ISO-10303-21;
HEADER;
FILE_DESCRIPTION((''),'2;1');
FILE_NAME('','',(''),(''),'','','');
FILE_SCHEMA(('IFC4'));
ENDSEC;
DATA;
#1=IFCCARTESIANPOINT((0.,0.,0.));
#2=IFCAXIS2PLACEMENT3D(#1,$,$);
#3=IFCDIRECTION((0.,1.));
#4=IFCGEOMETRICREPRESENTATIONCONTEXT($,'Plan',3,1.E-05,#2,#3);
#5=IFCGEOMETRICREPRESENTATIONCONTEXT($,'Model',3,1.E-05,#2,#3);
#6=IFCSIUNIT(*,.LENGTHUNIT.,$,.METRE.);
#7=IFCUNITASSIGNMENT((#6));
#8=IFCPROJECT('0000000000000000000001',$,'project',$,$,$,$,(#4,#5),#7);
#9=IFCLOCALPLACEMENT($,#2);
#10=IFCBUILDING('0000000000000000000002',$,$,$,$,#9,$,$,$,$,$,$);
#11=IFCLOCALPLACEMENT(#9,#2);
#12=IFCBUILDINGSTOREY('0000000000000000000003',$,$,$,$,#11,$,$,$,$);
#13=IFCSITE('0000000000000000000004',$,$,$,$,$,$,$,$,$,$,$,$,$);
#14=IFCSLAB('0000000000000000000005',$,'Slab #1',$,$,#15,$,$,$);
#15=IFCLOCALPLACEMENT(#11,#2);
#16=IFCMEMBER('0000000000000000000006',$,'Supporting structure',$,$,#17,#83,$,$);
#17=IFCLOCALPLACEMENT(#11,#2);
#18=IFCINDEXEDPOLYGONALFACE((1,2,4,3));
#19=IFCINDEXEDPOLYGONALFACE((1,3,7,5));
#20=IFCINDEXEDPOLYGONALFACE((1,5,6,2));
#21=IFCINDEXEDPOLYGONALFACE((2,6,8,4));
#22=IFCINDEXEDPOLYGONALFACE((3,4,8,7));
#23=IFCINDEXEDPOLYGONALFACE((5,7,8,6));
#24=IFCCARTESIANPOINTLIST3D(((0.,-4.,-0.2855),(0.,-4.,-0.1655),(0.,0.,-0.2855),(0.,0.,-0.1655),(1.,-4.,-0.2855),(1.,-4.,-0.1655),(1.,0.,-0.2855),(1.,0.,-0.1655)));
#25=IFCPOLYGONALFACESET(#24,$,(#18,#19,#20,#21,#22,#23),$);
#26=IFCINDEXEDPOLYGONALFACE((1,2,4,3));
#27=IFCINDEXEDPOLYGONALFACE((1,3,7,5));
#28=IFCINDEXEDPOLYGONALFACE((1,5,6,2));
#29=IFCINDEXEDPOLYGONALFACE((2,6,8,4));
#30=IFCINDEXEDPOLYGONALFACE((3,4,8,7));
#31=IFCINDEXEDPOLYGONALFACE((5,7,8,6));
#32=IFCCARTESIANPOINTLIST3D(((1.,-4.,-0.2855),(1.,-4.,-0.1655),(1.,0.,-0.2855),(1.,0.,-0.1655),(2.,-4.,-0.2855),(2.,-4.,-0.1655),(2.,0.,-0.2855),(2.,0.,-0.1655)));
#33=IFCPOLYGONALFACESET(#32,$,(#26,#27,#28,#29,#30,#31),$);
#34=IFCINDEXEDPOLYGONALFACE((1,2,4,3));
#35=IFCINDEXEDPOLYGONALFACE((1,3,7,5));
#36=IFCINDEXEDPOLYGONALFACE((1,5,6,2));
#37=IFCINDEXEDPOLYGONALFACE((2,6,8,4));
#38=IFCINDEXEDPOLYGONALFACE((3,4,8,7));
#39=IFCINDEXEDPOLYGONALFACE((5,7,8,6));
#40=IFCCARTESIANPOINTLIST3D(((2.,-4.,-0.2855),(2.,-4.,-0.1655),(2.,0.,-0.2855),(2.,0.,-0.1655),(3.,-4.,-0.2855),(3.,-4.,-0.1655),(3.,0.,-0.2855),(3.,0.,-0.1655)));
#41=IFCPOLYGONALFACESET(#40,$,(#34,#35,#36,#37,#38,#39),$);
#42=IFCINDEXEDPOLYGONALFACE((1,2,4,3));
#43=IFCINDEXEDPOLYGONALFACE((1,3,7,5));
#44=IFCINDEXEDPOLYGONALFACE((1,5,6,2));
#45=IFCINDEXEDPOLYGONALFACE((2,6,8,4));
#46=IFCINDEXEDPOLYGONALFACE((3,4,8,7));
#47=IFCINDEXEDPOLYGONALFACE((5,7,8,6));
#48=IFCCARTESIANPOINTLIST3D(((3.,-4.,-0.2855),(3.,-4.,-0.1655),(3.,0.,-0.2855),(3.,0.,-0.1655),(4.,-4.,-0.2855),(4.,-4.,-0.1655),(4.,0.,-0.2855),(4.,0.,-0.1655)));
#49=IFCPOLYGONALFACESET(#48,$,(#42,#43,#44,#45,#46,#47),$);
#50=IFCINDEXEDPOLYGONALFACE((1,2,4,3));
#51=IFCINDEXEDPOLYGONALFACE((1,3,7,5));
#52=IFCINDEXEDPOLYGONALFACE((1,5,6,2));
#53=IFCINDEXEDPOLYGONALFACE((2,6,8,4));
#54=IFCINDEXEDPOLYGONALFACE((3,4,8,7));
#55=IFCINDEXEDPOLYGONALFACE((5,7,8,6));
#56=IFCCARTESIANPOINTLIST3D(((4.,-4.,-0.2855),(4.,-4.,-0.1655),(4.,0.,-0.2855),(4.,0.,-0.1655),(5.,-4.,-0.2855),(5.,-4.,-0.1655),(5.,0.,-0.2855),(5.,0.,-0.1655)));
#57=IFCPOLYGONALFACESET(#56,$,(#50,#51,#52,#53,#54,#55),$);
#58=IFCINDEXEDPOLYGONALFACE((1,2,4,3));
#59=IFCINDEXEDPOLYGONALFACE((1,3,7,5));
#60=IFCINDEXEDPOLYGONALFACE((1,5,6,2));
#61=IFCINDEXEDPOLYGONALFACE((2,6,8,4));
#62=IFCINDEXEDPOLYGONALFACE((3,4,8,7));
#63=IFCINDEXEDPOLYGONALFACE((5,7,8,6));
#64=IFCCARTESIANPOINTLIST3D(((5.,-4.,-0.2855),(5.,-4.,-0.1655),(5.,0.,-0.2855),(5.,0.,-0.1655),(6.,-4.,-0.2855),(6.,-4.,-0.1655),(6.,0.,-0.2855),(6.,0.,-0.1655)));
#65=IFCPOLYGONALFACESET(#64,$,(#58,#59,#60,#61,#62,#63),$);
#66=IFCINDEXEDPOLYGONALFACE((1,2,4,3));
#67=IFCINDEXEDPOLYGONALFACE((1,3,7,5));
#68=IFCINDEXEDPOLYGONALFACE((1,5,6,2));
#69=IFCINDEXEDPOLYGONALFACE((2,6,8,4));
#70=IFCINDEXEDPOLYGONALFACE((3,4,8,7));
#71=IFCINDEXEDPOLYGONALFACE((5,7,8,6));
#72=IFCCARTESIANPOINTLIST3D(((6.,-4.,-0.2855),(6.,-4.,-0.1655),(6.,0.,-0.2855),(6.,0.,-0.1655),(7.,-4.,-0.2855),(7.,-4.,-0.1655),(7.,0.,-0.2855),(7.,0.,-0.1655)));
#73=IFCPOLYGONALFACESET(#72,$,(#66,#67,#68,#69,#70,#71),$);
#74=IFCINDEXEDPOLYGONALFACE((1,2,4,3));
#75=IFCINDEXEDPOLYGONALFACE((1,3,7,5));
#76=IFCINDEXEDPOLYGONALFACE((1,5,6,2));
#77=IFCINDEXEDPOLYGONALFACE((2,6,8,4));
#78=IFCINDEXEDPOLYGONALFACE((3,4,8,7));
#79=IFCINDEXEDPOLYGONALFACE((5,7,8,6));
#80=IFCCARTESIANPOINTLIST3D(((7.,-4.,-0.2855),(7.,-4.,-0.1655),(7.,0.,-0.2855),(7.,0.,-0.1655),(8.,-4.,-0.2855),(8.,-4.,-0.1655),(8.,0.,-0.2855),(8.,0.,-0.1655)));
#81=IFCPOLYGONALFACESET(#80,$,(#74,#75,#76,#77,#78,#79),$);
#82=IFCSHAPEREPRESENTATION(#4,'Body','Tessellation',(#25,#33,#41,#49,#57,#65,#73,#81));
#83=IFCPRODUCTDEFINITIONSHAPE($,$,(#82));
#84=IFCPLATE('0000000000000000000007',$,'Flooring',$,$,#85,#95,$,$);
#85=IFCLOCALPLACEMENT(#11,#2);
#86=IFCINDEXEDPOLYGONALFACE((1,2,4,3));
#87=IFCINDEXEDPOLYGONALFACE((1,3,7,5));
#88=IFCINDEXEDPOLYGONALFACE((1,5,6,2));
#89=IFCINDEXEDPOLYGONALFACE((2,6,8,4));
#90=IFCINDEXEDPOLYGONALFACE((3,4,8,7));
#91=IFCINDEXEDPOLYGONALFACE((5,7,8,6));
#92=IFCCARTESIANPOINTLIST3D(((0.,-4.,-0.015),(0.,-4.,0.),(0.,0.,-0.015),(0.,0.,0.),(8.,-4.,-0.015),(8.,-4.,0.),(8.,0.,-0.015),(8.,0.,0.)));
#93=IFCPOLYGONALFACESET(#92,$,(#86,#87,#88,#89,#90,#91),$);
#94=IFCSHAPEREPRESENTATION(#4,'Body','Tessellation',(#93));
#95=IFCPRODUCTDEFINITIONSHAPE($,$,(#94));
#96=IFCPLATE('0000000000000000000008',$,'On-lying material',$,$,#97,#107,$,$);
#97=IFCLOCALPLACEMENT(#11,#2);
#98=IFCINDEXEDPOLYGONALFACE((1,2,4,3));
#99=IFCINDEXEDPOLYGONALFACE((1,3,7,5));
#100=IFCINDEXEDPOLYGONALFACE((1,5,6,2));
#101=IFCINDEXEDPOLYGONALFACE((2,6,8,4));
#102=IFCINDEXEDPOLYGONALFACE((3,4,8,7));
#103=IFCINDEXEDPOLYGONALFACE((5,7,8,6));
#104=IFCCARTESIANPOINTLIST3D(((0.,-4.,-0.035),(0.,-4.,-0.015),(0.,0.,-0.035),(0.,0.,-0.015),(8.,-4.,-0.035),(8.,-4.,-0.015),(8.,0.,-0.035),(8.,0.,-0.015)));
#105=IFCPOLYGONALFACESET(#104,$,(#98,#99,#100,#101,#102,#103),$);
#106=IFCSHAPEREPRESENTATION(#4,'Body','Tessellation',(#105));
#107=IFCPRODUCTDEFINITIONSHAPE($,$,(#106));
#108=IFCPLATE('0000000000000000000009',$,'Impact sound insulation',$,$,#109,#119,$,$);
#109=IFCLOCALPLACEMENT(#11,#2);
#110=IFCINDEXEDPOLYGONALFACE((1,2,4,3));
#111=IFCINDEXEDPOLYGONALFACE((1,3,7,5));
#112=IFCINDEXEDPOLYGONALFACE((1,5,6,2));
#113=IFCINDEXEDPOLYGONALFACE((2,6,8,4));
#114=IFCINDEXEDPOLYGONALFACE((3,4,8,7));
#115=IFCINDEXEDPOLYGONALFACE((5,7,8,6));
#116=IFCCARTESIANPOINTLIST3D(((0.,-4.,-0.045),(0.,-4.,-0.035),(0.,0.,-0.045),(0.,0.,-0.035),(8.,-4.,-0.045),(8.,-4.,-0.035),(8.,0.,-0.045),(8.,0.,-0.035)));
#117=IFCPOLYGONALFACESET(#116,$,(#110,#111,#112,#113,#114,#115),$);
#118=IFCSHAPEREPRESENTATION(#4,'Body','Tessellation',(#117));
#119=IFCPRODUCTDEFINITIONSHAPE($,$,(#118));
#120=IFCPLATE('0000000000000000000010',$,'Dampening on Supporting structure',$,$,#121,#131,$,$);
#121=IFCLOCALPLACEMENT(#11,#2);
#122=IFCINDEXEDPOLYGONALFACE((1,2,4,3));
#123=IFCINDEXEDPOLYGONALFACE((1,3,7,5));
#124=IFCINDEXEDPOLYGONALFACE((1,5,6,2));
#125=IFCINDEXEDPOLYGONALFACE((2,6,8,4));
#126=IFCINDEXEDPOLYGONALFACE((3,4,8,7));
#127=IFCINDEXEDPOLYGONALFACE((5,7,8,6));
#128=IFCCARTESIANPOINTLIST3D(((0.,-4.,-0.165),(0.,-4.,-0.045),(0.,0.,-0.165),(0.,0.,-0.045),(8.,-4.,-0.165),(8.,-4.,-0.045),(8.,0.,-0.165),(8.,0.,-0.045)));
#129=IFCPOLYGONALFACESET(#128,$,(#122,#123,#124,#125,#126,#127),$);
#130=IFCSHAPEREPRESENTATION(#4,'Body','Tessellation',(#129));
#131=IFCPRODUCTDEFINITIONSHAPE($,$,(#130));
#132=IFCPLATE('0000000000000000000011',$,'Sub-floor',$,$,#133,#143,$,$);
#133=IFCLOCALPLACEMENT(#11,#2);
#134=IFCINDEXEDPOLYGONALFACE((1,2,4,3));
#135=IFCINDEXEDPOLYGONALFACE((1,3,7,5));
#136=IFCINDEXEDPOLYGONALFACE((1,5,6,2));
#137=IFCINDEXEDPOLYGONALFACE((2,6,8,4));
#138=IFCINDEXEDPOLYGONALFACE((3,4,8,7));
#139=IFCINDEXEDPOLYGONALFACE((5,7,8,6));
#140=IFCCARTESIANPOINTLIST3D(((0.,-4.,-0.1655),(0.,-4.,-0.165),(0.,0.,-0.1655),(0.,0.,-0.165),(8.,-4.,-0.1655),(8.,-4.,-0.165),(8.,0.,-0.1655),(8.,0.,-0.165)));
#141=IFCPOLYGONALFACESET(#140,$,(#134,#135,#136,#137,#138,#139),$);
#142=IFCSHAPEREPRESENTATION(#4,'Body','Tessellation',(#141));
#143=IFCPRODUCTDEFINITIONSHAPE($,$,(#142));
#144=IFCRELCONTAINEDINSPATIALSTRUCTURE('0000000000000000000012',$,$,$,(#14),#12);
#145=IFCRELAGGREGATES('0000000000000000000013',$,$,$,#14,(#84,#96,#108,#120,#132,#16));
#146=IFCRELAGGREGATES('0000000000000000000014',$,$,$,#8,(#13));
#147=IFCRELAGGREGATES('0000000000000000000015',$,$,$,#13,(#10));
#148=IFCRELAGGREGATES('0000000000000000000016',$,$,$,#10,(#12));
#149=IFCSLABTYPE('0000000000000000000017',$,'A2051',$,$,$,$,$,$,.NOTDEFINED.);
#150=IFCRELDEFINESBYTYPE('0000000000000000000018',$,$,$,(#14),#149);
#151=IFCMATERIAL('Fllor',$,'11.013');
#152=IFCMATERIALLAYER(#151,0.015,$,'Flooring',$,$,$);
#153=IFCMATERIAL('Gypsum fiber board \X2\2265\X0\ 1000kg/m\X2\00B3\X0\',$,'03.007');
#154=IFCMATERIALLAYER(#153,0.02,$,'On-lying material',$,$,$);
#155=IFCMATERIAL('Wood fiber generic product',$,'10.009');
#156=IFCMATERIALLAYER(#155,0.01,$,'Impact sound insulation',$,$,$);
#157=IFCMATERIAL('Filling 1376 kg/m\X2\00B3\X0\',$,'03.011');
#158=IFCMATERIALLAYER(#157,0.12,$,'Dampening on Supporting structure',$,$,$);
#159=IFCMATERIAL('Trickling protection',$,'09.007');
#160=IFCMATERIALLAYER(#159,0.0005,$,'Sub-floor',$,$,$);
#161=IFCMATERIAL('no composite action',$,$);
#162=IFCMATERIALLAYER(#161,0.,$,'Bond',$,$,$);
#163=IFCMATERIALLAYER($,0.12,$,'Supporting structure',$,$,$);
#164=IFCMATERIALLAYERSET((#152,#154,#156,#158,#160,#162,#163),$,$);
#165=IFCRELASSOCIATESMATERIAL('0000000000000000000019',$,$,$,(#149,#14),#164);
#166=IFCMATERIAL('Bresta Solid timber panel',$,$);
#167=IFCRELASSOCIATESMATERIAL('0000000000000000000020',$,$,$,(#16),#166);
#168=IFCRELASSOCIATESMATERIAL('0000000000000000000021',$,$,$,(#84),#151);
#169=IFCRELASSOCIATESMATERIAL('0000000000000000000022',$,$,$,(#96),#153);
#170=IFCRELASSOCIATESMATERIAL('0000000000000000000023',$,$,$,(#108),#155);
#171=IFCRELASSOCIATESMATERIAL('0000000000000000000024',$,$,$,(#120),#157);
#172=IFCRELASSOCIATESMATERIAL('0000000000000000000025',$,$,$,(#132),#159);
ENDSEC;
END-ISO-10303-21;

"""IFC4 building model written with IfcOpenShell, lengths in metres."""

from ifc_helpers import new_model, si_unit, direction, frame, frame_2d, origin, origin_with_axes, place, context, project, spatial, rectangle, extrude, material, layer, layer_set, type_object, element, aggregate, save


model = new_model("IFC4")

# Units and contexts
plan_context = context("Plan", 3, precision=1e-05, world=origin(), true_north=direction((0.0, 1.0)))
model_context = context("Model", 3, precision=1e-05, world=origin(), true_north=direction((0.0, 1.0)))
ifc_project = project(units=[si_unit("LENGTHUNIT", "METRE")], contexts=[plan_context, model_context])

# Site, building, storey
site = spatial("IfcSite", under=ifc_project)
building_placement = place(None, origin())
building = spatial("IfcBuilding", under=site, at=building_placement)
storey_placement = place(building_placement, origin())
storey = spatial("IfcBuildingStorey", under=building, at=storey_placement)

# Slab, member, plates
ifc_material_1 = material(Name="Fllor", Category="11.013")
ifc_layer_1 = layer(ifc_material_1, 0.015, Name="Flooring")
ifc_material_2 = material(Name="Gypsum fiber board ≥ 1000kg/m³", Category="03.007")
ifc_layer_2 = layer(ifc_material_2, 0.02, Name="On-lying material")
ifc_material_3 = material(Name="Wood fiber generic product", Category="10.009")
ifc_layer_3 = layer(ifc_material_3, 0.01, Name="Impact sound insulation")
ifc_material_4 = material(Name="Filling 1376 kg/m³", Category="03.011")
ifc_layer_4 = layer(ifc_material_4, 0.12, Name="Dampening on Supporting structure")
ifc_material_5 = material(Name="Trickling protection", Category="09.007")
ifc_layer_5 = layer(ifc_material_5, 0.0005, Name="Sub-floor")
ifc_material_6 = material(Name="no composite action")
ifc_layer_6 = layer(ifc_material_6, 0.0, Name="Bond")
ifc_layer_7 = layer(None, 0.12, Name="Supporting structure")
ifc_layer_set = layer_set([ifc_layer_1, ifc_layer_2, ifc_layer_3, ifc_layer_4, ifc_layer_5, ifc_layer_6, ifc_layer_7])
slab_type = type_object("IfcSlabType", Name="A2051", PredefinedType="NOTDEFINED", material=ifc_layer_set)
slab_placement = place(None, frame((0.0, 0.0, 0.0), z_axis=(0.0, 0.0, -1.0), x_axis=(1.0, 0.0, 0.0)))
slab = element("IfcSlab", 1, at=slab_placement, inside=storey, type_object=slab_type, material=ifc_layer_set, Name="Slab #1")
ifc_material_7 = material(Name="Bresta Solid timber panel")
member_placement = place(slab_placement, origin())
member = element("IfcMember", 2, at=member_placement, material=ifc_material_7, Name="Supporting structure", context=plan_context, shape_type="SweptSolid", body=[
    extrude(rectangle(XDim=1.0, YDim=0.12, at=frame_2d((0.5, 0.06), x_axis=(1.0, 0.0))), frame((0.0, 4.0, 0.1655), z_axis=(0.0, -1.0, 0.0), x_axis=(1.0, 0.0, 0.0)), (0.0, 0.0, 1.0), 4.0),
    extrude(rectangle(XDim=1.0, YDim=0.12, at=frame_2d((0.5, 0.06), x_axis=(1.0, 0.0))), frame((1.0, 4.0, 0.1655), z_axis=(0.0, -1.0, 0.0), x_axis=(1.0, 0.0, 0.0)), (0.0, 0.0, 1.0), 4.0),
    extrude(rectangle(XDim=1.0, YDim=0.12, at=frame_2d((0.5, 0.06), x_axis=(1.0, 0.0))), frame((2.0, 4.0, 0.1655), z_axis=(0.0, -1.0, 0.0), x_axis=(1.0, 0.0, 0.0)), (0.0, 0.0, 1.0), 4.0),
    extrude(rectangle(XDim=1.0, YDim=0.12, at=frame_2d((0.5, 0.06), x_axis=(1.0, 0.0))), frame((3.0, 4.0, 0.1655), z_axis=(0.0, -1.0, 0.0), x_axis=(1.0, 0.0, 0.0)), (0.0, 0.0, 1.0), 4.0),
    extrude(rectangle(XDim=1.0, YDim=0.12, at=frame_2d((0.5, 0.06), x_axis=(1.0, 0.0))), frame((4.0, 4.0, 0.1655), z_axis=(0.0, -1.0, 0.0), x_axis=(1.0, 0.0, 0.0)), (0.0, 0.0, 1.0), 4.0),
    extrude(rectangle(XDim=1.0, YDim=0.12, at=frame_2d((0.5, 0.06), x_axis=(1.0, 0.0))), frame((5.0, 4.0, 0.1655), z_axis=(0.0, -1.0, 0.0), x_axis=(1.0, 0.0, 0.0)), (0.0, 0.0, 1.0), 4.0),
    extrude(rectangle(XDim=1.0, YDim=0.12, at=frame_2d((0.5, 0.06), x_axis=(1.0, 0.0))), frame((6.0, 4.0, 0.1655), z_axis=(0.0, -1.0, 0.0), x_axis=(1.0, 0.0, 0.0)), (0.0, 0.0, 1.0), 4.0),
    extrude(rectangle(XDim=1.0, YDim=0.12, at=frame_2d((0.5, 0.06), x_axis=(1.0, 0.0))), frame((7.0, 4.0, 0.1655), z_axis=(0.0, -1.0, 0.0), x_axis=(1.0, 0.0, 0.0)), (0.0, 0.0, 1.0), 4.0),
])
plate_1_placement = place(slab_placement, origin())
plate_1 = element("IfcPlate", 3, at=plate_1_placement, material=ifc_material_1, Name="Flooring", context=plan_context, shape_type="SweptSolid", body=[
    extrude(rectangle(XDim=8.0, YDim=4.0, at=frame_2d((4.0, 2.0), x_axis=(1.0, 0.0))), origin_with_axes(), (0.0, 0.0, 1.0), 0.015),
])
plate_2_placement = place(slab_placement, origin())
plate_2 = element("IfcPlate", 4, at=plate_2_placement, material=ifc_material_2, Name="On-lying material", context=plan_context, shape_type="SweptSolid", body=[
    extrude(rectangle(XDim=8.0, YDim=4.0, at=frame_2d((4.0, 2.0), x_axis=(1.0, 0.0))), frame((0.0, 0.0, 0.015), z_axis=(0.0, 0.0, 1.0), x_axis=(1.0, 0.0, 0.0)), (0.0, 0.0, 1.0), 0.02),
])
plate_3_placement = place(slab_placement, origin())
plate_3 = element("IfcPlate", 5, at=plate_3_placement, material=ifc_material_3, Name="Impact sound insulation", context=plan_context, shape_type="SweptSolid", body=[
    extrude(rectangle(XDim=8.0, YDim=4.0, at=frame_2d((4.0, 2.0), x_axis=(1.0, 0.0))), frame((0.0, 0.0, 0.035), z_axis=(0.0, 0.0, 1.0), x_axis=(1.0, 0.0, 0.0)), (0.0, 0.0, 1.0), 0.01),
])
plate_4_placement = place(slab_placement, origin())
plate_4 = element("IfcPlate", 6, at=plate_4_placement, material=ifc_material_4, Name="Dampening on Supporting structure", context=plan_context, shape_type="SweptSolid", body=[
    extrude(rectangle(XDim=8.0, YDim=4.0, at=frame_2d((4.0, 2.0), x_axis=(1.0, 0.0))), frame((0.0, 0.0, 0.045), z_axis=(0.0, 0.0, 1.0), x_axis=(1.0, 0.0, 0.0)), (0.0, 0.0, 1.0), 0.12),
])
plate_5_placement = place(slab_placement, origin())
plate_5 = element("IfcPlate", 7, at=plate_5_placement, material=ifc_material_5, Name="Sub-floor", context=plan_context, shape_type="SweptSolid", body=[
    extrude(rectangle(XDim=8.0, YDim=4.0, at=frame_2d((4.0, 2.0), x_axis=(1.0, 0.0))), frame((0.0, 0.0, 0.165), z_axis=(0.0, 0.0, 1.0), x_axis=(1.0, 0.0, 0.0)), (0.0, 0.0, 1.0), 0.0005),
])
aggregate(slab, [plate_1, plate_2, plate_3, plate_4, plate_5, member])

save(model, "model.ifc")
